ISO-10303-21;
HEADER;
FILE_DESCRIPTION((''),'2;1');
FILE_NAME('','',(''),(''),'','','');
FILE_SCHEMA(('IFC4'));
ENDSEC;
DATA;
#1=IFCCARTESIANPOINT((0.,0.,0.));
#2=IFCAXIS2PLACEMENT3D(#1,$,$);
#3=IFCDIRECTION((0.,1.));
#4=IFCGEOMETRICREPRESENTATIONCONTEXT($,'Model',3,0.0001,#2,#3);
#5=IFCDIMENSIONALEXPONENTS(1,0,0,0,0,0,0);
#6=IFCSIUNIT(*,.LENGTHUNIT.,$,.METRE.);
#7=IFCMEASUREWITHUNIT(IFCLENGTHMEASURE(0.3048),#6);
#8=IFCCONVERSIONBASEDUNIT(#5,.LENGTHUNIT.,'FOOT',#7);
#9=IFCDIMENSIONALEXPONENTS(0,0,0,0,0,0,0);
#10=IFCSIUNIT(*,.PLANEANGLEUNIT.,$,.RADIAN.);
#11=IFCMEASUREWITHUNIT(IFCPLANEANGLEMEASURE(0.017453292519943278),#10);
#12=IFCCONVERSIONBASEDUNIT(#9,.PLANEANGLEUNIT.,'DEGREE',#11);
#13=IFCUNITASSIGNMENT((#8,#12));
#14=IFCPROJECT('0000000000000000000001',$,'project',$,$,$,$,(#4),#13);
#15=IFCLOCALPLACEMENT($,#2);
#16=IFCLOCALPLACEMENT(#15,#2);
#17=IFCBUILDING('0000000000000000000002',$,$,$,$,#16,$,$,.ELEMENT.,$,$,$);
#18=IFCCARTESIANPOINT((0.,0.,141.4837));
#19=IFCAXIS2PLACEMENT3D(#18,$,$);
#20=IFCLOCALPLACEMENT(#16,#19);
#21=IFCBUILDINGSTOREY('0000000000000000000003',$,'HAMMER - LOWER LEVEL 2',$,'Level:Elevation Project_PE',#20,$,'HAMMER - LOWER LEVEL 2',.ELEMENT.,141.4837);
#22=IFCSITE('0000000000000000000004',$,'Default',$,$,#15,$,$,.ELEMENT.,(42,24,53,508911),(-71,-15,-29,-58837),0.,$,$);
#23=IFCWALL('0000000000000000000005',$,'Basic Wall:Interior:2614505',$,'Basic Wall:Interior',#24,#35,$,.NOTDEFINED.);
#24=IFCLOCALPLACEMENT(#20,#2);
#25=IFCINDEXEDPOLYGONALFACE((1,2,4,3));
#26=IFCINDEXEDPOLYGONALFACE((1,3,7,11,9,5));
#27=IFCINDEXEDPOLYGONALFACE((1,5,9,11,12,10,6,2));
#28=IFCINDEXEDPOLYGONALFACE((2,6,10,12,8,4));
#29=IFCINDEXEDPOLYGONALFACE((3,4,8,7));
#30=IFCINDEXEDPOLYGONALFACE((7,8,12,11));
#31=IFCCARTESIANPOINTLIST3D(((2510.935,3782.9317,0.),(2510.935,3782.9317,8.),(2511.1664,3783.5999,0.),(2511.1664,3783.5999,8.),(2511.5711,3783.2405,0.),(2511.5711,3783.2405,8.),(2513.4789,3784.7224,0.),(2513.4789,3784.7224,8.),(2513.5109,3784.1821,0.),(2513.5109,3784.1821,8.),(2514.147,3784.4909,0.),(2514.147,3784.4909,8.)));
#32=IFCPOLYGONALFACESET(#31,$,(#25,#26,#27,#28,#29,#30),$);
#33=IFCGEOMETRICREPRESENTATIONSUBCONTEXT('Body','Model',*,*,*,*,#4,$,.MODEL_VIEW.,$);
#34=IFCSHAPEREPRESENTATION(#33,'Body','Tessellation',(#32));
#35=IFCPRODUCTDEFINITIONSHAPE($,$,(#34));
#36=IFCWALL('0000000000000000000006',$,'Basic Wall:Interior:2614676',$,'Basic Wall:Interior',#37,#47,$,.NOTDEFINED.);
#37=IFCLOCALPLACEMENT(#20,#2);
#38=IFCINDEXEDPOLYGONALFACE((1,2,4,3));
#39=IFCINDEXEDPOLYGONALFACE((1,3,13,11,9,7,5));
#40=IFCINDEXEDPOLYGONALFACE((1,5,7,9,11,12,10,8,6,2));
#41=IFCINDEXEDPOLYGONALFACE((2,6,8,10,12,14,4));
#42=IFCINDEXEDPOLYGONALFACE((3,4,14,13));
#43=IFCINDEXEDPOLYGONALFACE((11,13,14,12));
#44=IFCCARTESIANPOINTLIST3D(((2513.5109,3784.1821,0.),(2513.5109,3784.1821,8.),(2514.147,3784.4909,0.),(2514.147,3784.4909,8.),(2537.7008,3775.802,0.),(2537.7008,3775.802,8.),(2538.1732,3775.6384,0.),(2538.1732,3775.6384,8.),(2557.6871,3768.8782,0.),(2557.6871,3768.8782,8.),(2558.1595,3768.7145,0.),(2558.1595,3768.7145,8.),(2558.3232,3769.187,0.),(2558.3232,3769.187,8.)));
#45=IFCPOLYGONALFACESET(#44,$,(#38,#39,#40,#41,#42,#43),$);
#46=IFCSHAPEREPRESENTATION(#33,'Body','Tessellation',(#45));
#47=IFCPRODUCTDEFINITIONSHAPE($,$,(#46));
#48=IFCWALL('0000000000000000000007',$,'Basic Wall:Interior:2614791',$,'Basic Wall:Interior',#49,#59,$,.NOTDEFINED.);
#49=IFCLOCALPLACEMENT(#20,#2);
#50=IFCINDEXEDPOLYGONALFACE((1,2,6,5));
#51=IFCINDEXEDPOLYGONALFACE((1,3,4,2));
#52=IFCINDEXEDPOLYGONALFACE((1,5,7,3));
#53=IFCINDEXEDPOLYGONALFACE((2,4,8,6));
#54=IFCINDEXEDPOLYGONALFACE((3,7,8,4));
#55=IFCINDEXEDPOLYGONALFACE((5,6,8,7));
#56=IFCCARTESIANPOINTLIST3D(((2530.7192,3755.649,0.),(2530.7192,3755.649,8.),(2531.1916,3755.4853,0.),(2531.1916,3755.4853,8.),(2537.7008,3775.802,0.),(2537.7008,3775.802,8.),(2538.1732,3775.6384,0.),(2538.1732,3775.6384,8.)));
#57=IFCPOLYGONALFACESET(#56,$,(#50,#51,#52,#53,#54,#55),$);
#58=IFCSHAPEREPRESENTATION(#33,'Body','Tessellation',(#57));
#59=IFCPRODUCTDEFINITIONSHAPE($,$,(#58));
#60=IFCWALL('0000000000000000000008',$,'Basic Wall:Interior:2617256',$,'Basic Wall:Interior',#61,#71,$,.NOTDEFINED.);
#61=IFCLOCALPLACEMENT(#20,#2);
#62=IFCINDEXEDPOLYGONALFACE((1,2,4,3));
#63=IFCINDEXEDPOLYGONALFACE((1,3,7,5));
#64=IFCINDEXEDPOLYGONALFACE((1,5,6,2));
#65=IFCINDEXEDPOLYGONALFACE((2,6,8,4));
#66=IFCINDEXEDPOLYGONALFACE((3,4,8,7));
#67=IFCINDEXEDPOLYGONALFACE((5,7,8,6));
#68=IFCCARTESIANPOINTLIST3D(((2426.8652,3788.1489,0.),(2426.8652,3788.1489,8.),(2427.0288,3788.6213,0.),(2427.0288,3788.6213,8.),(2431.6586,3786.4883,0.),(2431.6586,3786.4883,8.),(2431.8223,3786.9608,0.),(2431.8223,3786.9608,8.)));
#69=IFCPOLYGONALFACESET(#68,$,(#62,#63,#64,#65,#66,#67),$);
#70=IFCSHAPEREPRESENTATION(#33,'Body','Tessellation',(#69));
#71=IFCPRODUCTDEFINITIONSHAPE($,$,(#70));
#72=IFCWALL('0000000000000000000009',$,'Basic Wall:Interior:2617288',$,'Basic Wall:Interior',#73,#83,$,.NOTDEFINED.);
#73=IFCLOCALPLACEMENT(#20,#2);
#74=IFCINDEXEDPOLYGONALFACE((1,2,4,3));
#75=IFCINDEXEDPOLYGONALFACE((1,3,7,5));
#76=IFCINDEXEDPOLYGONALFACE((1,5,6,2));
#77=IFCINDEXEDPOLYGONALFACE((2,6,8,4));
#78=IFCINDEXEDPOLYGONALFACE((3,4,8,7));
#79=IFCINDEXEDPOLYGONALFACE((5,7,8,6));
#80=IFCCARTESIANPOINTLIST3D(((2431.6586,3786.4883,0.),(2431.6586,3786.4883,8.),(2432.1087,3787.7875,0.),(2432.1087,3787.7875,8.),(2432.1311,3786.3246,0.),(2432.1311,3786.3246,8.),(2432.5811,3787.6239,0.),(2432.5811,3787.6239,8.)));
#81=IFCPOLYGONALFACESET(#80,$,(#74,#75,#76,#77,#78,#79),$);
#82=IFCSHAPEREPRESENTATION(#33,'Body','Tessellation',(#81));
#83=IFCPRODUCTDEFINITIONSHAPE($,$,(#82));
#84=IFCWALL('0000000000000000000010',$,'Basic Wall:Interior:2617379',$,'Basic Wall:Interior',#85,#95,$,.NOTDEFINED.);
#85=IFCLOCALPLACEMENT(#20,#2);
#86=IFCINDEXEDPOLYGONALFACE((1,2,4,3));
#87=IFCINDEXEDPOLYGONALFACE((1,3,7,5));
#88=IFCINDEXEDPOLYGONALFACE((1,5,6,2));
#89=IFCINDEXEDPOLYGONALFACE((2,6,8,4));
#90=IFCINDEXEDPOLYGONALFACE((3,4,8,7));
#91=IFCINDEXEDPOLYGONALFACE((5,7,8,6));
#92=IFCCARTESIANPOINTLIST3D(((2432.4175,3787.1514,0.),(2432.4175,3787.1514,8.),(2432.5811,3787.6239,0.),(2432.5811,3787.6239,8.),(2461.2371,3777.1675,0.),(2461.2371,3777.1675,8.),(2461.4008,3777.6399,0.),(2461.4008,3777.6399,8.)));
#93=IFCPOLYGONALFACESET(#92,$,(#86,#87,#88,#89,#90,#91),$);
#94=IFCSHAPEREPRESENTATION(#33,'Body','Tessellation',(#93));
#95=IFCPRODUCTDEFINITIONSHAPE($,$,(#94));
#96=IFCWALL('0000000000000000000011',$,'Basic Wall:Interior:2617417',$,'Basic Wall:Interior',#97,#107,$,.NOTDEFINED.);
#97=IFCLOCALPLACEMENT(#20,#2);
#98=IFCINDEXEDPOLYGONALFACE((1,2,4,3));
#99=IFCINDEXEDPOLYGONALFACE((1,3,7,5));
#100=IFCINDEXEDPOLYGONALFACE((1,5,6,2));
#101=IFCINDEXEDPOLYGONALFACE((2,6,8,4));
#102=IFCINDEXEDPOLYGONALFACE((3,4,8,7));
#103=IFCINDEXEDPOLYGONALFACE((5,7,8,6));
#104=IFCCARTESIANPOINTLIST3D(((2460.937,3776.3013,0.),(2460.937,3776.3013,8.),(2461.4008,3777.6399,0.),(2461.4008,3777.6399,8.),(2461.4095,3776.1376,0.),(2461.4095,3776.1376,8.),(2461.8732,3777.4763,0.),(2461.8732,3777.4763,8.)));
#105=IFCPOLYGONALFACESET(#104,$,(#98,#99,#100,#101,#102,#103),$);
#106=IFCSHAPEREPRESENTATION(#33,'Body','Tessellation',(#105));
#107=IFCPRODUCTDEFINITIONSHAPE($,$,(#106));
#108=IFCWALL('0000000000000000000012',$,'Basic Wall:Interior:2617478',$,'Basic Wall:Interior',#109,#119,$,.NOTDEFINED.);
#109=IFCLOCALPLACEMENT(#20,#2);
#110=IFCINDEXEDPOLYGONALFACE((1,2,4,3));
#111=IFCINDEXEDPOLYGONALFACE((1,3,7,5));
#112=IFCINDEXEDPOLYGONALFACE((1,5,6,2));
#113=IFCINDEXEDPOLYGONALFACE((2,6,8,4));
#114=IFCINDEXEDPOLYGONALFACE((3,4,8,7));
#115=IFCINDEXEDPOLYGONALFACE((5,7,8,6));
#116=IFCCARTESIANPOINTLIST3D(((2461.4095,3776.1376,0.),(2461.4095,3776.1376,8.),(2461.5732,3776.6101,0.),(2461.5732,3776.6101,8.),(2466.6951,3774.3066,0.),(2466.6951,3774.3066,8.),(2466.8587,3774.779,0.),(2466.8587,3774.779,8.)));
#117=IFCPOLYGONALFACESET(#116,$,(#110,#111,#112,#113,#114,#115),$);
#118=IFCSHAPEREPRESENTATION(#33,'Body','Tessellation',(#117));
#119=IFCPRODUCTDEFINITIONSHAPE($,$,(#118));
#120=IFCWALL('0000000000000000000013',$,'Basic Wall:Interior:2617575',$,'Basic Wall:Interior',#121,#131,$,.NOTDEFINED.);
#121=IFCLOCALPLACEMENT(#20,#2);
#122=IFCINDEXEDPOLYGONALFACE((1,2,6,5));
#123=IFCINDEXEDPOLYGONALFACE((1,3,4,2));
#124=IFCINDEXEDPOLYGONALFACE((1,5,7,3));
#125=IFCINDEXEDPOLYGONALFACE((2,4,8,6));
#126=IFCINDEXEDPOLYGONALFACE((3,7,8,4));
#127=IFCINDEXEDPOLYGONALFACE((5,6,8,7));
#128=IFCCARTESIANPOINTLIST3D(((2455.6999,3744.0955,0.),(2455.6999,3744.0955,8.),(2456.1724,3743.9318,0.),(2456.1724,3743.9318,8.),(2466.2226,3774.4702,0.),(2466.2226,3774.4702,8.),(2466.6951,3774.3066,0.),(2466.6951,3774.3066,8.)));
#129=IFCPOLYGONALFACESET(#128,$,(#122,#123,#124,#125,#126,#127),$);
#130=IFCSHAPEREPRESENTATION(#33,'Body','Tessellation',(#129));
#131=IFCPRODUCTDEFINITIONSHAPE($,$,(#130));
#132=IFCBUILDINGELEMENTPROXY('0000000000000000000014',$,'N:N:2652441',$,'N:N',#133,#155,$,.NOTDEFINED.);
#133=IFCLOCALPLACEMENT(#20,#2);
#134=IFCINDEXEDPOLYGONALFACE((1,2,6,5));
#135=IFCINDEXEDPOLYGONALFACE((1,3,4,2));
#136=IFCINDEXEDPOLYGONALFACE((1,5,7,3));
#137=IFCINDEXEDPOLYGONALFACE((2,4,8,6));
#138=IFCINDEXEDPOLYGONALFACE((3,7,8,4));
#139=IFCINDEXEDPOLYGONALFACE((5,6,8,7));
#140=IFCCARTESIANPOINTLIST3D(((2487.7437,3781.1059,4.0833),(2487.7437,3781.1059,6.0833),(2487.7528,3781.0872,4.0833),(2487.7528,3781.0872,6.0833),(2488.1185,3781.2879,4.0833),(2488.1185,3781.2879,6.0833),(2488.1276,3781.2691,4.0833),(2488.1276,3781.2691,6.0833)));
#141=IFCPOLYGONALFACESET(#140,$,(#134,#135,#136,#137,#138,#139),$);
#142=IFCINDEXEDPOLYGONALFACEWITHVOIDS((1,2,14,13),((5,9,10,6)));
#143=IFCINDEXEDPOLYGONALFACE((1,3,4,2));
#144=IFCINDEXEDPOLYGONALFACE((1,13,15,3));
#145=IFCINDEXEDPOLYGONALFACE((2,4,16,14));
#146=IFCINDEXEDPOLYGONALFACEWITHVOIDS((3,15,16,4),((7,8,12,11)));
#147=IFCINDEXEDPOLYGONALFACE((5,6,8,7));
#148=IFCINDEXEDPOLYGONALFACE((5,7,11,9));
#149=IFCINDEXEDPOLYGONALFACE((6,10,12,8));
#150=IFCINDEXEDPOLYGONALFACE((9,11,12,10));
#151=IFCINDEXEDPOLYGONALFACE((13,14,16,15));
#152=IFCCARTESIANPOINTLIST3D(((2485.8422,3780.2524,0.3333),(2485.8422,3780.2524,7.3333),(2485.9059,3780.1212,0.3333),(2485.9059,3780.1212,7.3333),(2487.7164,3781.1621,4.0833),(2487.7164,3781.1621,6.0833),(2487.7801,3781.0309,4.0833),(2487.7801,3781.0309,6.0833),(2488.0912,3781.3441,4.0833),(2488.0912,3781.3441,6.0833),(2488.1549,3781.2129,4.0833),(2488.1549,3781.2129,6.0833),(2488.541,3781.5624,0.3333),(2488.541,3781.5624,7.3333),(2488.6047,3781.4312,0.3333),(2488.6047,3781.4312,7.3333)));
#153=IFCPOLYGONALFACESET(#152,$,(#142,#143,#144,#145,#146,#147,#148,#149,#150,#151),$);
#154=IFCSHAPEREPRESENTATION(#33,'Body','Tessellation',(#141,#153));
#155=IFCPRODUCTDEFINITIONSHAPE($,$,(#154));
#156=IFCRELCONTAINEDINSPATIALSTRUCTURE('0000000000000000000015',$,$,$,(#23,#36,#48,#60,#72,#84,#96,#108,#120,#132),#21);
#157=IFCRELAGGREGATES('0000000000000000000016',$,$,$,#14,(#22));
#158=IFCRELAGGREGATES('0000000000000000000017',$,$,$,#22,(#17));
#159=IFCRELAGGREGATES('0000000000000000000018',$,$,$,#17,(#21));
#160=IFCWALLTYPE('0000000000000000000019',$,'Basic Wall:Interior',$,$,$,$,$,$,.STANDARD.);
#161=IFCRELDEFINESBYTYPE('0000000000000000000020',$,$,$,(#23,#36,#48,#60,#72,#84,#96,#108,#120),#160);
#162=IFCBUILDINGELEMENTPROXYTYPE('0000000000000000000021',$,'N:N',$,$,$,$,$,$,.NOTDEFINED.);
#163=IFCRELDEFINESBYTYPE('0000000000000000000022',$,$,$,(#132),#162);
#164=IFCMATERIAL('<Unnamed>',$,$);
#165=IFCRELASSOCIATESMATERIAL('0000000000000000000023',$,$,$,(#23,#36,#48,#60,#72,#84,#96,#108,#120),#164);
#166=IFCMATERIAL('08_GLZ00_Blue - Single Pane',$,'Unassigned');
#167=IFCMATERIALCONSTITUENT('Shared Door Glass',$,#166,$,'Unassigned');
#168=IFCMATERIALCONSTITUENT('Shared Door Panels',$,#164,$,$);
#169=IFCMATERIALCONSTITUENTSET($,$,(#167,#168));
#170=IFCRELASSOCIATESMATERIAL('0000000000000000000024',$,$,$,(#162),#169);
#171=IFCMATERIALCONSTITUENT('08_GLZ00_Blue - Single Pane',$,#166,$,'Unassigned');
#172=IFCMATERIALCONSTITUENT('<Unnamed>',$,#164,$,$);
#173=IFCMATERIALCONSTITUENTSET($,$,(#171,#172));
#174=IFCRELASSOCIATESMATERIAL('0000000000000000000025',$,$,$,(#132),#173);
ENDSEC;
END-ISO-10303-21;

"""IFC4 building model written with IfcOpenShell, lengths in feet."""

from ifc_helpers import new_model, entity, si_unit, converted_unit, direction, frame, origin, place, context, subcontext, project, spatial, indexed_curve, outline, extrude, source, transform, mapped, material, constituent, constituent_set, type_object, type_shapes, element, save


model = new_model("IFC4")

# Units and contexts
model_context = context("Model", 3, precision=0.0001, world=origin(), true_north=direction((0.0, 1.0)))
body_context = subcontext(model_context, "Body", "Model", "MODEL_VIEW")
ifc_project = project(units=[converted_unit("LENGTHUNIT", "FOOT", entity("IfcLengthMeasure", 0.3048), si_unit("LENGTHUNIT", "METRE"), dimensions=[1, 0, 0, 0, 0, 0, 0]), converted_unit("PLANEANGLEUNIT", "DEGREE", entity("IfcPlaneAngleMeasure", 0.017453292519943278), si_unit("PLANEANGLEUNIT", "RADIAN"), dimensions=[0, 0, 0, 0, 0, 0, 0])], contexts=[model_context])

# Site, building, storey
site_placement = place(None, origin())
site = spatial("IfcSite", under=ifc_project, at=site_placement, Name="Default", CompositionType="ELEMENT", RefLatitude=(42, 24, 53, 508911), RefLongitude=(-71, -15, -29, -58837), RefElevation=0.0)
building_placement = place(site_placement, origin())
building = spatial("IfcBuilding", under=site, at=building_placement, CompositionType="ELEMENT")
storey_placement = place(building_placement, frame((0.0, 0.0, 141.4837)))
storey = spatial("IfcBuildingStorey", under=building, at=storey_placement, Name="HAMMER - LOWER LEVEL 2", ObjectType="Level:Elevation Project_PE", LongName="HAMMER - LOWER LEVEL 2", CompositionType="ELEMENT", Elevation=141.4837)

# Shared definitions
ifc_material_1 = material(Name="<Unnamed>")
wall_type = type_object("IfcWallType", Name="Basic Wall:Interior", PredefinedType="STANDARD")

# Walls
wall_1_placement = place(storey_placement, frame((2510.8258, 3783.1566, 0.0), z_axis=(0.0, 0.0, 1.0), x_axis=(0.899615, 0.436683, 0.0)))
element("IfcWall", 1, at=wall_1_placement, inside=storey, type_object=wall_type, material=ifc_material_1, Name="Basic Wall:Interior:2614505", ObjectType="Basic Wall:Interior", PredefinedType="NOTDEFINED", context=body_context, shape_type="SweptSolid", body=[
    extrude(outline(indexed_curve([(3.5705, -0.25), (3.0705, 0.25), (0.5, 0.25), (0.0, -0.25), (0.7071, -0.25), (2.8634, -0.25), (3.5705, -0.25)], self_intersect=False)), origin(), (0.0, 0.0, 1.0), 8.0),
])
wall_2_placement = place(storey_placement, frame((2513.5927, 3784.4183, 0.0), z_axis=(0.0, 0.0, 1.0), x_axis=(0.944906, -0.327342, 0.0)))
element("IfcWall", 2, at=wall_2_placement, inside=storey, type_object=wall_type, material=ifc_material_1, Name="Basic Wall:Interior:2614676", ObjectType="Basic Wall:Interior", PredefinedType="NOTDEFINED", context=body_context, shape_type="SweptSolid", body=[
    extrude(outline(indexed_curve([(47.252, -0.25), (47.252, 0.25), (0.5, 0.25), (0.0, -0.25), (25.6003, -0.25), (26.1003, -0.25), (46.752, -0.25), (47.252, -0.25)], self_intersect=False)), origin(), (0.0, 0.0, 1.0), 8.0),
])
wall_3_placement = place(storey_placement, frame((2537.937, 3775.7202, 0.0), z_axis=(0.0, 0.0, 1.0), x_axis=(-0.327342, -0.944906, 0.0)))
element("IfcWall", 3, at=wall_3_placement, inside=storey, type_object=wall_type, material=ifc_material_1, Name="Basic Wall:Interior:2614791", ObjectType="Basic Wall:Interior", PredefinedType="NOTDEFINED", context=body_context, shape_type="SweptSolid", body=[
    extrude(outline(indexed_curve([(21.3281, 0.25), (0.0, 0.25), (0.0, -0.25), (21.3281, -0.25), (21.3281, 0.25)], self_intersect=False)), origin(), (0.0, 0.0, 1.0), 8.0),
])
wall_4_placement = place(storey_placement, frame((2426.947, 3788.3851, 0.0), z_axis=(0.0, 0.0, 1.0), x_axis=(0.944906, -0.327342, 0.0)))
element("IfcWall", 4, at=wall_4_placement, inside=storey, type_object=wall_type, material=ifc_material_1, Name="Basic Wall:Interior:2617256", ObjectType="Basic Wall:Interior", PredefinedType="NOTDEFINED", context=body_context, shape_type="SweptSolid", body=[
    extrude(outline(indexed_curve([(5.0729, 0.25), (0.0, 0.25), (0.0, -0.25), (5.0729, -0.25), (5.0729, 0.25)], self_intersect=False)), origin(), (0.0, 0.0, 1.0), 8.0),
])
wall_5_placement = place(storey_placement, frame((2431.8948, 3786.4065, 0.0), z_axis=(0.0, 0.0, 1.0), x_axis=(0.327342, 0.944906, 0.0)))
element("IfcWall", 5, at=wall_5_placement, inside=storey, type_object=wall_type, material=ifc_material_1, Name="Basic Wall:Interior:2617288", ObjectType="Basic Wall:Interior", PredefinedType="NOTDEFINED", context=body_context, shape_type="SweptSolid", body=[
    extrude(outline(indexed_curve([(1.375, 0.25), (0.0, 0.25), (0.0, -0.25), (1.375, -0.25), (1.375, 0.25)], self_intersect=False)), origin(), (0.0, 0.0, 1.0), 8.0),
])
wall_6_placement = place(storey_placement, frame((2432.4993, 3787.3876, 0.0), z_axis=(0.0, 0.0, 1.0), x_axis=(0.944906, -0.327342, 0.0)))
element("IfcWall", 6, at=wall_6_placement, inside=storey, type_object=wall_type, material=ifc_material_1, Name="Basic Wall:Interior:2617379", ObjectType="Basic Wall:Interior", PredefinedType="NOTDEFINED", context=body_context, shape_type="SweptSolid", body=[
    extrude(outline(indexed_curve([(30.5, 0.25), (0.0, 0.25), (0.0, -0.25), (30.5, -0.25), (30.5, 0.25)], self_intersect=False)), origin(), (0.0, 0.0, 1.0), 8.0),
])
wall_7_placement = place(storey_placement, frame((2461.637, 3777.5581, 0.0), z_axis=(0.0, 0.0, 1.0), x_axis=(-0.327342, -0.944906, 0.0)))
element("IfcWall", 7, at=wall_7_placement, inside=storey, type_object=wall_type, material=ifc_material_1, Name="Basic Wall:Interior:2617417", ObjectType="Basic Wall:Interior", PredefinedType="NOTDEFINED", context=body_context, shape_type="SweptSolid", body=[
    extrude(outline(indexed_curve([(1.4167, 0.25), (0.0, 0.25), (0.0, -0.25), (1.4167, -0.25), (1.4167, 0.25)], self_intersect=False)), origin(), (0.0, 0.0, 1.0), 8.0),
])
wall_8_placement = place(storey_placement, frame((2461.4913, 3776.3739, 0.0), z_axis=(0.0, 0.0, 1.0), x_axis=(0.944906, -0.327342, 0.0)))
element("IfcWall", 8, at=wall_8_placement, inside=storey, type_object=wall_type, material=ifc_material_1, Name="Basic Wall:Interior:2617478", ObjectType="Basic Wall:Interior", PredefinedType="NOTDEFINED", context=body_context, shape_type="SweptSolid", body=[
    extrude(outline(indexed_curve([(5.5937, 0.25), (0.0, 0.25), (0.0, -0.25), (5.5937, -0.25), (5.5937, 0.25)], self_intersect=False)), origin(), (0.0, 0.0, 1.0), 8.0),
])
wall_9_placement = place(storey_placement, frame((2466.4588, 3774.3884, 0.0), z_axis=(0.0, 0.0, 1.0), x_axis=(-0.327342, -0.944906, 0.0)))
element("IfcWall", 9, at=wall_9_placement, inside=storey, type_object=wall_type, material=ifc_material_1, Name="Basic Wall:Interior:2617575", ObjectType="Basic Wall:Interior", PredefinedType="NOTDEFINED", context=body_context, shape_type="SweptSolid", body=[
    extrude(outline(indexed_curve([(32.1458, 0.25), (0.0, 0.25), (0.0, -0.25), (32.1458, -0.25), (32.1458, 0.25)], self_intersect=False)), origin(), (0.0, 0.0, 1.0), 8.0),
])

# Building element proxy
ifc_material_2 = material(Name="08_GLZ00_Blue - Single Pane", Category="Unassigned")
ifc_constituent_1 = constituent(ifc_material_2, Name="Shared Door Glass", Category="Unassigned")
ifc_constituent_2 = constituent(ifc_material_1, Name="Shared Door Panels")
ifc_constituent_set_1 = constituent_set(constituents=[ifc_constituent_1, ifc_constituent_2])
building_element_proxy_type_1 = type_object("IfcBuildingElementProxyType", Name="N:N", PredefinedType="NOTDEFINED", material=ifc_constituent_set_1)
shared_shape_1 = source(origin(), body_context, "Body", "SweptSolid", [
    extrude(outline(indexed_curve([(-0.2083, -0.0104), (0.2083, -0.0104), (0.2083, 0.0104), (-0.2083, 0.0104), (-0.2083, -0.0104)], self_intersect=False)), frame((-1.0775, -3.25, 3.75), z_axis=(0.0, 0.0, 1.0), x_axis=(-1.0, 0.0, 0.0)), (0.0, 0.0, 1.0), 2.0),
    extrude(outline(indexed_curve([(-3.5, -1.5), (3.5, -1.5), (3.5, 1.5), (-3.5, 1.5), (-3.5, -1.5)], self_intersect=False), holes=[indexed_curve([(-2.25, 0.5833), (-2.25, 1.0), (-0.25, 1.0), (-0.25, 0.5833), (-2.25, 0.5833)], self_intersect=False)]), frame((-0.2859, -3.3229, 3.5), z_axis=(0.0, 1.0, 0.0), x_axis=(0.0, 0.0, -1.0)), (0.0, 0.0, 1.0), 0.1458),
])
type_shapes(building_element_proxy_type_1, [shared_shape_1])
ifc_constituent_3 = constituent(ifc_material_2, Name="08_GLZ00_Blue - Single Pane", Category="Unassigned")
ifc_constituent_4 = constituent(ifc_material_1, Name="<Unnamed>")
ifc_constituent_set_2 = constituent_set(constituents=[ifc_constituent_3, ifc_constituent_4])
proxy_1_placement = place(storey_placement, frame((2488.3855, 3777.7932, 0.3333), z_axis=(0.0, 0.0, 1.0), x_axis=(-0.899615, -0.436683, 0.0)))
element("IfcBuildingElementProxy", 10, at=proxy_1_placement, inside=storey, type_object=building_element_proxy_type_1, material=ifc_constituent_set_2, Name="N:N:2652441", ObjectType="N:N", PredefinedType="NOTDEFINED", context=body_context, shape_type="MappedRepresentation", body=[
    mapped(shared_shape_1, transform((0.0, 0.0, 0.0), scale=1.0)),
])

save(model, "model.ifc")
